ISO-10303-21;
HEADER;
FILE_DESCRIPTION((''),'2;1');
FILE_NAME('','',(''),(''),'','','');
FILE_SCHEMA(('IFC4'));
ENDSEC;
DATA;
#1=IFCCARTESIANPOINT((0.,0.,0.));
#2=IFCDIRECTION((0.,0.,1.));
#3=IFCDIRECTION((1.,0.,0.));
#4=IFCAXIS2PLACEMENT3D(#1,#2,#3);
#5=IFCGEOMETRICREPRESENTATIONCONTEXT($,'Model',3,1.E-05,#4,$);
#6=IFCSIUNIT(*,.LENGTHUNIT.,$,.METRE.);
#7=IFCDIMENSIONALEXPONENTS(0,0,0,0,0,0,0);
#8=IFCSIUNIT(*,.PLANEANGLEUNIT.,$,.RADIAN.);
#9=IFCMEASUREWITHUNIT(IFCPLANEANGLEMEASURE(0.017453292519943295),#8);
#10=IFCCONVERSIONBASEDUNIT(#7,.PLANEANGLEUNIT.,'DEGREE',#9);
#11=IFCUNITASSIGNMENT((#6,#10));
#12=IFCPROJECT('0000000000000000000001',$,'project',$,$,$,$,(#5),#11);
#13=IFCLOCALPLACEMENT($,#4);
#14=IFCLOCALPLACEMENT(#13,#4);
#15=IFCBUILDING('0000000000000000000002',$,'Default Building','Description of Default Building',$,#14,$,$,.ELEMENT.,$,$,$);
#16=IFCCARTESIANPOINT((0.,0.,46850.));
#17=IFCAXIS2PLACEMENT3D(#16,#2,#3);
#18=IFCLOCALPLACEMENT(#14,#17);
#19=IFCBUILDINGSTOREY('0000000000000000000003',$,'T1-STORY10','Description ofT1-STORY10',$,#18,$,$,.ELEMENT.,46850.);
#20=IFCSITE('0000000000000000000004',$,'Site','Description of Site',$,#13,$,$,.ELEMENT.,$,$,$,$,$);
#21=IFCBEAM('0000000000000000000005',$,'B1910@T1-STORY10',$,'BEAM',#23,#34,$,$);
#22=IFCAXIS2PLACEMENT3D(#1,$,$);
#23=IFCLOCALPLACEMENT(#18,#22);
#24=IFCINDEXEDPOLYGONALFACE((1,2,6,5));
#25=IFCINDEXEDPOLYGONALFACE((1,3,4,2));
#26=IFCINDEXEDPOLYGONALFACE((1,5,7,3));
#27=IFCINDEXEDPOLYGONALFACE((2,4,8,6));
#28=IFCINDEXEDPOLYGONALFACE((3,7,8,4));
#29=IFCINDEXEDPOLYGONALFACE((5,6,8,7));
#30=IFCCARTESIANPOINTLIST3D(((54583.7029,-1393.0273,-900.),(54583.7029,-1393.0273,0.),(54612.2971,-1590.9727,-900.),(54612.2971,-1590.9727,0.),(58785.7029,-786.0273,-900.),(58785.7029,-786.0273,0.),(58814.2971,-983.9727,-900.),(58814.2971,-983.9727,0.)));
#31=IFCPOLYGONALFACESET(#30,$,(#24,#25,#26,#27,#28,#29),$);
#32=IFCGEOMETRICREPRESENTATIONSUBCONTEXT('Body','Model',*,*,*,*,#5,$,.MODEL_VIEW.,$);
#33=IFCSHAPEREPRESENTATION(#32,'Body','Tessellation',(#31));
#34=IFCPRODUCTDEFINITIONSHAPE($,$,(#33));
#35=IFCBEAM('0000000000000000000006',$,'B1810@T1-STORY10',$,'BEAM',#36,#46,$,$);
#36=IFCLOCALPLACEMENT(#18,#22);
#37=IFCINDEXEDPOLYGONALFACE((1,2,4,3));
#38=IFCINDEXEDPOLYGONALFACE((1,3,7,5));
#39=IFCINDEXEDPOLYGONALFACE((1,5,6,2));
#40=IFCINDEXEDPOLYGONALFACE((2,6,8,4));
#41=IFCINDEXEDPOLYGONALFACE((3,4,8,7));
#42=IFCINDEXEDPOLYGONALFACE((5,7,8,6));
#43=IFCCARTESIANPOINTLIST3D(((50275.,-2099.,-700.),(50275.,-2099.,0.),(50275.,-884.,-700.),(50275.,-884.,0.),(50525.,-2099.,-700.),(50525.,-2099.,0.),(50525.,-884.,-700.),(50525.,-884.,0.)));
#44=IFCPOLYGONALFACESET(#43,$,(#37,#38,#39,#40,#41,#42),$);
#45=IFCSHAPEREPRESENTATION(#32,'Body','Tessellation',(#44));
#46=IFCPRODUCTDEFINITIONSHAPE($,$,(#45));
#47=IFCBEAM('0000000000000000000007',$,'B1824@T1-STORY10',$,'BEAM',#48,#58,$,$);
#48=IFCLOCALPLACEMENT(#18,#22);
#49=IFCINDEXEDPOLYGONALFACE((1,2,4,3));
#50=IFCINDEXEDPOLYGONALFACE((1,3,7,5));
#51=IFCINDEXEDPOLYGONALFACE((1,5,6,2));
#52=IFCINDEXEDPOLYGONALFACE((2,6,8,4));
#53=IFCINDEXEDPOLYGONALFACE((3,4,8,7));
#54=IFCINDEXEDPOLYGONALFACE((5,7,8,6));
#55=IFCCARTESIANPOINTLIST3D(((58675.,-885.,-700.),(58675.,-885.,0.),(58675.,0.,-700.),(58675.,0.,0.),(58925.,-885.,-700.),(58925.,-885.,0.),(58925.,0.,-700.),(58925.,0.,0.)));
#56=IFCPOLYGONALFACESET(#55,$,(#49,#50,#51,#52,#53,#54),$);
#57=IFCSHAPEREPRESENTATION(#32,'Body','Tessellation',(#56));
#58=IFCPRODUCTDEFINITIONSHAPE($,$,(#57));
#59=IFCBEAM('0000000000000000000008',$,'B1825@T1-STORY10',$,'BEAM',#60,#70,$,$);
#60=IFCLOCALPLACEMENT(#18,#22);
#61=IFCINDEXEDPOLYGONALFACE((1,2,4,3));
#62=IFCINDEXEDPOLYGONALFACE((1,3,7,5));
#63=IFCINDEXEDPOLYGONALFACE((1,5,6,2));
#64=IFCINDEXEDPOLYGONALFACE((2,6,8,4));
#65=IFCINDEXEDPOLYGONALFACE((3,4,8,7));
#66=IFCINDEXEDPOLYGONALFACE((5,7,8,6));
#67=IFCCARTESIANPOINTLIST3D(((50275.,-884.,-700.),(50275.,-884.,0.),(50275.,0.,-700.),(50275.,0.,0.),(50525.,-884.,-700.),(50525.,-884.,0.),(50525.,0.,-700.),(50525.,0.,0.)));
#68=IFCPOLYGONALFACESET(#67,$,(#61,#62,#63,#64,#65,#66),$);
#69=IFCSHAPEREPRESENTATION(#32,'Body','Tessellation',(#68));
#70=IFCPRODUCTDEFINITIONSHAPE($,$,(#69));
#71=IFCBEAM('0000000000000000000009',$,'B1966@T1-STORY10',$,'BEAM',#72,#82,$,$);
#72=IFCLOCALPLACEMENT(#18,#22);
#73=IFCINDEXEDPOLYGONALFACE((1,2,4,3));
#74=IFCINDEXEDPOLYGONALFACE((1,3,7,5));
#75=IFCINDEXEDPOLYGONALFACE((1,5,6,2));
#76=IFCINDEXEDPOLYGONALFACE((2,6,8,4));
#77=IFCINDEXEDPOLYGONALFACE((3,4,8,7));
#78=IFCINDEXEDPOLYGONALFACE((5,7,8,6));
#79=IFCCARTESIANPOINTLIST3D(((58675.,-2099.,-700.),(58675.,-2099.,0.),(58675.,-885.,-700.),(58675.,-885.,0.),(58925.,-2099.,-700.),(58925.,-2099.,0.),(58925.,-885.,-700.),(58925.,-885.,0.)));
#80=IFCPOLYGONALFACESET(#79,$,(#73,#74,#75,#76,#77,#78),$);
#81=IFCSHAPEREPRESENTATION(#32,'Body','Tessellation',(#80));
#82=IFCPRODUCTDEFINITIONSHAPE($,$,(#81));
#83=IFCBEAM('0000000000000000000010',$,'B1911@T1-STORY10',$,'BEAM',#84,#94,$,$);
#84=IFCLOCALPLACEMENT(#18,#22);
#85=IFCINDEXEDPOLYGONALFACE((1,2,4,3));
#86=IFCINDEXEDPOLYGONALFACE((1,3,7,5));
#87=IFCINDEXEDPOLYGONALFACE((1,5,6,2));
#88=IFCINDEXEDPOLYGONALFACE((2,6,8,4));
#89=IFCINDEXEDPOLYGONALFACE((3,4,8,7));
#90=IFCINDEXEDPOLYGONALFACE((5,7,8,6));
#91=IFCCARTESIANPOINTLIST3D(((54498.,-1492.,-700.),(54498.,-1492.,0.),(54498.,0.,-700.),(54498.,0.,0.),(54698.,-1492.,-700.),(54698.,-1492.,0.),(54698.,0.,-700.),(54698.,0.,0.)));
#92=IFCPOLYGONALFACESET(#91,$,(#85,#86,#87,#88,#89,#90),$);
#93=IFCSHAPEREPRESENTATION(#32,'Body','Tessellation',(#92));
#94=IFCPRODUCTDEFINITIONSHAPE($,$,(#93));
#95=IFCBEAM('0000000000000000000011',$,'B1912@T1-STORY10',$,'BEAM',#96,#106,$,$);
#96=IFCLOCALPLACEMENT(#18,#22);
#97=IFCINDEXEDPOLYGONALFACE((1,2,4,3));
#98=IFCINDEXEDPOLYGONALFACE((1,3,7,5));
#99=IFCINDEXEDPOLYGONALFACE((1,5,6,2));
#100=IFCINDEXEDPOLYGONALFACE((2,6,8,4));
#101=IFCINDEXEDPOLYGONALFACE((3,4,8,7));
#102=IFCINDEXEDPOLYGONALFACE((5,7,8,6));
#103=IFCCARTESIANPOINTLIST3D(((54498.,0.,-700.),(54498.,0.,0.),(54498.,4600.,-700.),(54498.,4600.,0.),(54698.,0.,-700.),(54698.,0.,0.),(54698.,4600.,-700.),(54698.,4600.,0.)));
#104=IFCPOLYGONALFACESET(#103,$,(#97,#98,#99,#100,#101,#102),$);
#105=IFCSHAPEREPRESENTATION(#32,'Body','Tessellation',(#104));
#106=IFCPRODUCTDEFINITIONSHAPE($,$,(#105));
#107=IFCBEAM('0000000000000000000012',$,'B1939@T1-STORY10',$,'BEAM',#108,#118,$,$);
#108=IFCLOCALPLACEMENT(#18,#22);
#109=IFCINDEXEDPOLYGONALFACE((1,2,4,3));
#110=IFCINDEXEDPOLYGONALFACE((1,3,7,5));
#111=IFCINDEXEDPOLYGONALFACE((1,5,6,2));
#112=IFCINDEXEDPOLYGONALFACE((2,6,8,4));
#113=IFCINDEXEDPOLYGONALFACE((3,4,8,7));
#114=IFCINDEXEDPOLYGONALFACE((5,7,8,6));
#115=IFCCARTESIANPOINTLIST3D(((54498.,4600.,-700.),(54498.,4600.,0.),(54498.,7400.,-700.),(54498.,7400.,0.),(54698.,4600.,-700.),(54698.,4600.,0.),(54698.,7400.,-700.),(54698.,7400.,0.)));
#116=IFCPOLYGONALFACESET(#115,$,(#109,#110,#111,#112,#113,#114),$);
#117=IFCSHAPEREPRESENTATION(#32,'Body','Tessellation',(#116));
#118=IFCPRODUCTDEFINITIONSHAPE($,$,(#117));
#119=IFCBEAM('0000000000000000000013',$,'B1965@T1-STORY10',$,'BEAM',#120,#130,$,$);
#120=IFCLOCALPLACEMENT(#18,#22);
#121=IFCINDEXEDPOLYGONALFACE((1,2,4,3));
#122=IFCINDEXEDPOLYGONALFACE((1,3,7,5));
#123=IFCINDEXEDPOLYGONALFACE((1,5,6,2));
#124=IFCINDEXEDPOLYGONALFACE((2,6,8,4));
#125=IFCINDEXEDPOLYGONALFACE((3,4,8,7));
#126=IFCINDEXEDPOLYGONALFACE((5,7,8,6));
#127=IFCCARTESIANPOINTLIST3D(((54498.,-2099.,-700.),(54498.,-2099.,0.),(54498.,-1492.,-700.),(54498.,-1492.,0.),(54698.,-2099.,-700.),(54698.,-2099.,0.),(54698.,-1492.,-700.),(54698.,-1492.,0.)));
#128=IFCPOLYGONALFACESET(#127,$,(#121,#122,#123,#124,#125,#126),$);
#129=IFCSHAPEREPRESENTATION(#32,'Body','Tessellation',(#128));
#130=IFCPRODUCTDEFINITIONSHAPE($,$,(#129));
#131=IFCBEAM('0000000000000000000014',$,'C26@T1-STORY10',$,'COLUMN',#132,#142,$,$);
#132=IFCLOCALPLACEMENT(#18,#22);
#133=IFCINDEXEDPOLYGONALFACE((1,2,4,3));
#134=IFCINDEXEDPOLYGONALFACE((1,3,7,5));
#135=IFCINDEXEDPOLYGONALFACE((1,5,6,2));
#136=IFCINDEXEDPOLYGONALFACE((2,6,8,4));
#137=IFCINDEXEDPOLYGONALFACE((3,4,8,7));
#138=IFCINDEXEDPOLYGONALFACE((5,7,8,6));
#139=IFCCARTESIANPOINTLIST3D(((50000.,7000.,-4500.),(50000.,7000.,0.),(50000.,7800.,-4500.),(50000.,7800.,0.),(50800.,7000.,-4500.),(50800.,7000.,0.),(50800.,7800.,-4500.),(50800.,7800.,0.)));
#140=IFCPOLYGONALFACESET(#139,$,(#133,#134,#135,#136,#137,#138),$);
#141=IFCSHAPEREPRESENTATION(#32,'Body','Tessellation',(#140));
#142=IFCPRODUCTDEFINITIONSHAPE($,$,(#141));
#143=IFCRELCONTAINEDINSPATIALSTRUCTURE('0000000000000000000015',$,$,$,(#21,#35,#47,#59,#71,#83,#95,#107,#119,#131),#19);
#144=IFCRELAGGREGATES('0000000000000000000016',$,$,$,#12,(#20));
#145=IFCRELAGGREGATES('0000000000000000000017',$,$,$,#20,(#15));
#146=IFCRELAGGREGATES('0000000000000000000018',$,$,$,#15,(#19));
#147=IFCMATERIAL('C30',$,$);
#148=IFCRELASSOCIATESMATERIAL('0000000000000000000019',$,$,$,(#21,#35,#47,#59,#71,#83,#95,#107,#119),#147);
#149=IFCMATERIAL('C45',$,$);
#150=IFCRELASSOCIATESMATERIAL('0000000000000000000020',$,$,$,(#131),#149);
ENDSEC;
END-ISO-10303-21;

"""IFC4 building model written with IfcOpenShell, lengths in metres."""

from ifc_helpers import new_model, entity, si_unit, converted_unit, frame, origin_with_axes, place, context, subcontext, project, spatial, rectangle, extrude, material, element, save


model = new_model("IFC4")

# Units and contexts
model_context = context("Model", 3, precision=1e-05, world=origin_with_axes())
body_context = subcontext(model_context, "Body", "Model", "MODEL_VIEW")
ifc_project = project(units=[si_unit("LENGTHUNIT", "METRE"), converted_unit("PLANEANGLEUNIT", "DEGREE", entity("IfcPlaneAngleMeasure", 0.017453292519943295), si_unit("PLANEANGLEUNIT", "RADIAN"), dimensions=[0, 0, 0, 0, 0, 0, 0])], contexts=[model_context])

# Site, building, storey
site_placement = place(None, origin_with_axes())
site = spatial("IfcSite", under=ifc_project, at=site_placement, Name="Site", Description="Description of Site", CompositionType="ELEMENT")
building_placement = place(site_placement, origin_with_axes())
building = spatial("IfcBuilding", under=site, at=building_placement, Name="Default Building", Description="Description of Default Building", CompositionType="ELEMENT")
storey_placement = place(building_placement, frame((0.0, 0.0, 46850.0), z_axis=(0.0, 0.0, 1.0), x_axis=(1.0, 0.0, 0.0)))
storey = spatial("IfcBuildingStorey", under=building, at=storey_placement, Name="T1-STORY10", Description="Description ofT1-STORY10", CompositionType="ELEMENT", Elevation=46850.0)

# Beams
ifc_material_1 = material(Name="C30")
beam_1_placement = place(storey_placement, frame((54598.0, -1492.0, -450.0), z_axis=(0.989727, 0.142971, 0.0), x_axis=(-0.142971, 0.989727, 0.0)))
element("IfcBeam", 1, at=beam_1_placement, inside=storey, material=ifc_material_1, Name="B1910@T1-STORY10", ObjectType="BEAM", context=body_context, shape_type="SweptSolid", body=[
    extrude(rectangle(XDim=200.0, YDim=900.0), origin_with_axes(), (0.0, 0.0, 1.0), 4245.6157),
])
beam_2_placement = place(storey_placement, frame((50400.0, -2099.0, -350.0), z_axis=(0.0, 1.0, 0.0), x_axis=(-1.0, 0.0, 0.0)))
element("IfcBeam", 2, at=beam_2_placement, inside=storey, material=ifc_material_1, Name="B1810@T1-STORY10", ObjectType="BEAM", context=body_context, shape_type="SweptSolid", body=[
    extrude(rectangle(XDim=250.0, YDim=700.0), origin_with_axes(), (0.0, 0.0, 1.0), 1215.0),
])
beam_3_placement = place(storey_placement, frame((58800.0, -885.0, -350.0), z_axis=(0.0, 1.0, 0.0), x_axis=(-1.0, 0.0, 0.0)))
element("IfcBeam", 3, at=beam_3_placement, inside=storey, material=ifc_material_1, Name="B1824@T1-STORY10", ObjectType="BEAM", context=body_context, shape_type="SweptSolid", body=[
    extrude(rectangle(XDim=250.0, YDim=700.0), origin_with_axes(), (0.0, 0.0, 1.0), 885.0),
])
beam_4_placement = place(storey_placement, frame((50400.0, -884.0, -350.0), z_axis=(0.0, 1.0, 0.0), x_axis=(-1.0, 0.0, 0.0)))
element("IfcBeam", 4, at=beam_4_placement, inside=storey, material=ifc_material_1, Name="B1825@T1-STORY10", ObjectType="BEAM", context=body_context, shape_type="SweptSolid", body=[
    extrude(rectangle(XDim=250.0, YDim=700.0), origin_with_axes(), (0.0, 0.0, 1.0), 884.0),
])
beam_5_placement = place(storey_placement, frame((58800.0, -2099.0, -350.0), z_axis=(0.0, 1.0, 0.0), x_axis=(-1.0, 0.0, 0.0)))
element("IfcBeam", 5, at=beam_5_placement, inside=storey, material=ifc_material_1, Name="B1966@T1-STORY10", ObjectType="BEAM", context=body_context, shape_type="SweptSolid", body=[
    extrude(rectangle(XDim=250.0, YDim=700.0), origin_with_axes(), (0.0, 0.0, 1.0), 1214.0),
])
beam_6_placement = place(storey_placement, frame((54598.0, -1492.0, -350.0), z_axis=(0.0, 1.0, 0.0), x_axis=(-1.0, 0.0, 0.0)))
element("IfcBeam", 6, at=beam_6_placement, inside=storey, material=ifc_material_1, Name="B1911@T1-STORY10", ObjectType="BEAM", context=body_context, shape_type="SweptSolid", body=[
    extrude(rectangle(XDim=200.0, YDim=700.0), origin_with_axes(), (0.0, 0.0, 1.0), 1492.0),
])
beam_7_placement = place(storey_placement, frame((54598.0, 0.0, -350.0), z_axis=(0.0, 1.0, 0.0), x_axis=(-1.0, 0.0, 0.0)))
element("IfcBeam", 7, at=beam_7_placement, inside=storey, material=ifc_material_1, Name="B1912@T1-STORY10", ObjectType="BEAM", context=body_context, shape_type="SweptSolid", body=[
    extrude(rectangle(XDim=200.0, YDim=700.0), origin_with_axes(), (0.0, 0.0, 1.0), 4600.0),
])
beam_8_placement = place(storey_placement, frame((54598.0, 4600.0, -350.0), z_axis=(0.0, 1.0, 0.0), x_axis=(-1.0, 0.0, 0.0)))
element("IfcBeam", 8, at=beam_8_placement, inside=storey, material=ifc_material_1, Name="B1939@T1-STORY10", ObjectType="BEAM", context=body_context, shape_type="SweptSolid", body=[
    extrude(rectangle(XDim=200.0, YDim=700.0), origin_with_axes(), (0.0, 0.0, 1.0), 2800.0),
])
beam_9_placement = place(storey_placement, frame((54598.0, -2099.0, -350.0), z_axis=(0.0, 1.0, 0.0), x_axis=(-1.0, 0.0, 0.0)))
element("IfcBeam", 9, at=beam_9_placement, inside=storey, material=ifc_material_1, Name="B1965@T1-STORY10", ObjectType="BEAM", context=body_context, shape_type="SweptSolid", body=[
    extrude(rectangle(XDim=200.0, YDim=700.0), origin_with_axes(), (0.0, 0.0, 1.0), 607.0),
])
ifc_material_2 = material(Name="C45")
beam_10_placement = place(storey_placement, frame((50400.0, 7400.0, -4500.0), z_axis=(0.0, 0.0, 1.0), x_axis=(-1.0, 0.0, 0.0)))
element("IfcBeam", 10, at=beam_10_placement, inside=storey, material=ifc_material_2, Name="C26@T1-STORY10", ObjectType="COLUMN", context=body_context, shape_type="SweptSolid", body=[
    extrude(rectangle(XDim=800.0, YDim=800.0), origin_with_axes(), (0.0, 0.0, 1.0), 4500.0),
])

save(model, "model.ifc")
